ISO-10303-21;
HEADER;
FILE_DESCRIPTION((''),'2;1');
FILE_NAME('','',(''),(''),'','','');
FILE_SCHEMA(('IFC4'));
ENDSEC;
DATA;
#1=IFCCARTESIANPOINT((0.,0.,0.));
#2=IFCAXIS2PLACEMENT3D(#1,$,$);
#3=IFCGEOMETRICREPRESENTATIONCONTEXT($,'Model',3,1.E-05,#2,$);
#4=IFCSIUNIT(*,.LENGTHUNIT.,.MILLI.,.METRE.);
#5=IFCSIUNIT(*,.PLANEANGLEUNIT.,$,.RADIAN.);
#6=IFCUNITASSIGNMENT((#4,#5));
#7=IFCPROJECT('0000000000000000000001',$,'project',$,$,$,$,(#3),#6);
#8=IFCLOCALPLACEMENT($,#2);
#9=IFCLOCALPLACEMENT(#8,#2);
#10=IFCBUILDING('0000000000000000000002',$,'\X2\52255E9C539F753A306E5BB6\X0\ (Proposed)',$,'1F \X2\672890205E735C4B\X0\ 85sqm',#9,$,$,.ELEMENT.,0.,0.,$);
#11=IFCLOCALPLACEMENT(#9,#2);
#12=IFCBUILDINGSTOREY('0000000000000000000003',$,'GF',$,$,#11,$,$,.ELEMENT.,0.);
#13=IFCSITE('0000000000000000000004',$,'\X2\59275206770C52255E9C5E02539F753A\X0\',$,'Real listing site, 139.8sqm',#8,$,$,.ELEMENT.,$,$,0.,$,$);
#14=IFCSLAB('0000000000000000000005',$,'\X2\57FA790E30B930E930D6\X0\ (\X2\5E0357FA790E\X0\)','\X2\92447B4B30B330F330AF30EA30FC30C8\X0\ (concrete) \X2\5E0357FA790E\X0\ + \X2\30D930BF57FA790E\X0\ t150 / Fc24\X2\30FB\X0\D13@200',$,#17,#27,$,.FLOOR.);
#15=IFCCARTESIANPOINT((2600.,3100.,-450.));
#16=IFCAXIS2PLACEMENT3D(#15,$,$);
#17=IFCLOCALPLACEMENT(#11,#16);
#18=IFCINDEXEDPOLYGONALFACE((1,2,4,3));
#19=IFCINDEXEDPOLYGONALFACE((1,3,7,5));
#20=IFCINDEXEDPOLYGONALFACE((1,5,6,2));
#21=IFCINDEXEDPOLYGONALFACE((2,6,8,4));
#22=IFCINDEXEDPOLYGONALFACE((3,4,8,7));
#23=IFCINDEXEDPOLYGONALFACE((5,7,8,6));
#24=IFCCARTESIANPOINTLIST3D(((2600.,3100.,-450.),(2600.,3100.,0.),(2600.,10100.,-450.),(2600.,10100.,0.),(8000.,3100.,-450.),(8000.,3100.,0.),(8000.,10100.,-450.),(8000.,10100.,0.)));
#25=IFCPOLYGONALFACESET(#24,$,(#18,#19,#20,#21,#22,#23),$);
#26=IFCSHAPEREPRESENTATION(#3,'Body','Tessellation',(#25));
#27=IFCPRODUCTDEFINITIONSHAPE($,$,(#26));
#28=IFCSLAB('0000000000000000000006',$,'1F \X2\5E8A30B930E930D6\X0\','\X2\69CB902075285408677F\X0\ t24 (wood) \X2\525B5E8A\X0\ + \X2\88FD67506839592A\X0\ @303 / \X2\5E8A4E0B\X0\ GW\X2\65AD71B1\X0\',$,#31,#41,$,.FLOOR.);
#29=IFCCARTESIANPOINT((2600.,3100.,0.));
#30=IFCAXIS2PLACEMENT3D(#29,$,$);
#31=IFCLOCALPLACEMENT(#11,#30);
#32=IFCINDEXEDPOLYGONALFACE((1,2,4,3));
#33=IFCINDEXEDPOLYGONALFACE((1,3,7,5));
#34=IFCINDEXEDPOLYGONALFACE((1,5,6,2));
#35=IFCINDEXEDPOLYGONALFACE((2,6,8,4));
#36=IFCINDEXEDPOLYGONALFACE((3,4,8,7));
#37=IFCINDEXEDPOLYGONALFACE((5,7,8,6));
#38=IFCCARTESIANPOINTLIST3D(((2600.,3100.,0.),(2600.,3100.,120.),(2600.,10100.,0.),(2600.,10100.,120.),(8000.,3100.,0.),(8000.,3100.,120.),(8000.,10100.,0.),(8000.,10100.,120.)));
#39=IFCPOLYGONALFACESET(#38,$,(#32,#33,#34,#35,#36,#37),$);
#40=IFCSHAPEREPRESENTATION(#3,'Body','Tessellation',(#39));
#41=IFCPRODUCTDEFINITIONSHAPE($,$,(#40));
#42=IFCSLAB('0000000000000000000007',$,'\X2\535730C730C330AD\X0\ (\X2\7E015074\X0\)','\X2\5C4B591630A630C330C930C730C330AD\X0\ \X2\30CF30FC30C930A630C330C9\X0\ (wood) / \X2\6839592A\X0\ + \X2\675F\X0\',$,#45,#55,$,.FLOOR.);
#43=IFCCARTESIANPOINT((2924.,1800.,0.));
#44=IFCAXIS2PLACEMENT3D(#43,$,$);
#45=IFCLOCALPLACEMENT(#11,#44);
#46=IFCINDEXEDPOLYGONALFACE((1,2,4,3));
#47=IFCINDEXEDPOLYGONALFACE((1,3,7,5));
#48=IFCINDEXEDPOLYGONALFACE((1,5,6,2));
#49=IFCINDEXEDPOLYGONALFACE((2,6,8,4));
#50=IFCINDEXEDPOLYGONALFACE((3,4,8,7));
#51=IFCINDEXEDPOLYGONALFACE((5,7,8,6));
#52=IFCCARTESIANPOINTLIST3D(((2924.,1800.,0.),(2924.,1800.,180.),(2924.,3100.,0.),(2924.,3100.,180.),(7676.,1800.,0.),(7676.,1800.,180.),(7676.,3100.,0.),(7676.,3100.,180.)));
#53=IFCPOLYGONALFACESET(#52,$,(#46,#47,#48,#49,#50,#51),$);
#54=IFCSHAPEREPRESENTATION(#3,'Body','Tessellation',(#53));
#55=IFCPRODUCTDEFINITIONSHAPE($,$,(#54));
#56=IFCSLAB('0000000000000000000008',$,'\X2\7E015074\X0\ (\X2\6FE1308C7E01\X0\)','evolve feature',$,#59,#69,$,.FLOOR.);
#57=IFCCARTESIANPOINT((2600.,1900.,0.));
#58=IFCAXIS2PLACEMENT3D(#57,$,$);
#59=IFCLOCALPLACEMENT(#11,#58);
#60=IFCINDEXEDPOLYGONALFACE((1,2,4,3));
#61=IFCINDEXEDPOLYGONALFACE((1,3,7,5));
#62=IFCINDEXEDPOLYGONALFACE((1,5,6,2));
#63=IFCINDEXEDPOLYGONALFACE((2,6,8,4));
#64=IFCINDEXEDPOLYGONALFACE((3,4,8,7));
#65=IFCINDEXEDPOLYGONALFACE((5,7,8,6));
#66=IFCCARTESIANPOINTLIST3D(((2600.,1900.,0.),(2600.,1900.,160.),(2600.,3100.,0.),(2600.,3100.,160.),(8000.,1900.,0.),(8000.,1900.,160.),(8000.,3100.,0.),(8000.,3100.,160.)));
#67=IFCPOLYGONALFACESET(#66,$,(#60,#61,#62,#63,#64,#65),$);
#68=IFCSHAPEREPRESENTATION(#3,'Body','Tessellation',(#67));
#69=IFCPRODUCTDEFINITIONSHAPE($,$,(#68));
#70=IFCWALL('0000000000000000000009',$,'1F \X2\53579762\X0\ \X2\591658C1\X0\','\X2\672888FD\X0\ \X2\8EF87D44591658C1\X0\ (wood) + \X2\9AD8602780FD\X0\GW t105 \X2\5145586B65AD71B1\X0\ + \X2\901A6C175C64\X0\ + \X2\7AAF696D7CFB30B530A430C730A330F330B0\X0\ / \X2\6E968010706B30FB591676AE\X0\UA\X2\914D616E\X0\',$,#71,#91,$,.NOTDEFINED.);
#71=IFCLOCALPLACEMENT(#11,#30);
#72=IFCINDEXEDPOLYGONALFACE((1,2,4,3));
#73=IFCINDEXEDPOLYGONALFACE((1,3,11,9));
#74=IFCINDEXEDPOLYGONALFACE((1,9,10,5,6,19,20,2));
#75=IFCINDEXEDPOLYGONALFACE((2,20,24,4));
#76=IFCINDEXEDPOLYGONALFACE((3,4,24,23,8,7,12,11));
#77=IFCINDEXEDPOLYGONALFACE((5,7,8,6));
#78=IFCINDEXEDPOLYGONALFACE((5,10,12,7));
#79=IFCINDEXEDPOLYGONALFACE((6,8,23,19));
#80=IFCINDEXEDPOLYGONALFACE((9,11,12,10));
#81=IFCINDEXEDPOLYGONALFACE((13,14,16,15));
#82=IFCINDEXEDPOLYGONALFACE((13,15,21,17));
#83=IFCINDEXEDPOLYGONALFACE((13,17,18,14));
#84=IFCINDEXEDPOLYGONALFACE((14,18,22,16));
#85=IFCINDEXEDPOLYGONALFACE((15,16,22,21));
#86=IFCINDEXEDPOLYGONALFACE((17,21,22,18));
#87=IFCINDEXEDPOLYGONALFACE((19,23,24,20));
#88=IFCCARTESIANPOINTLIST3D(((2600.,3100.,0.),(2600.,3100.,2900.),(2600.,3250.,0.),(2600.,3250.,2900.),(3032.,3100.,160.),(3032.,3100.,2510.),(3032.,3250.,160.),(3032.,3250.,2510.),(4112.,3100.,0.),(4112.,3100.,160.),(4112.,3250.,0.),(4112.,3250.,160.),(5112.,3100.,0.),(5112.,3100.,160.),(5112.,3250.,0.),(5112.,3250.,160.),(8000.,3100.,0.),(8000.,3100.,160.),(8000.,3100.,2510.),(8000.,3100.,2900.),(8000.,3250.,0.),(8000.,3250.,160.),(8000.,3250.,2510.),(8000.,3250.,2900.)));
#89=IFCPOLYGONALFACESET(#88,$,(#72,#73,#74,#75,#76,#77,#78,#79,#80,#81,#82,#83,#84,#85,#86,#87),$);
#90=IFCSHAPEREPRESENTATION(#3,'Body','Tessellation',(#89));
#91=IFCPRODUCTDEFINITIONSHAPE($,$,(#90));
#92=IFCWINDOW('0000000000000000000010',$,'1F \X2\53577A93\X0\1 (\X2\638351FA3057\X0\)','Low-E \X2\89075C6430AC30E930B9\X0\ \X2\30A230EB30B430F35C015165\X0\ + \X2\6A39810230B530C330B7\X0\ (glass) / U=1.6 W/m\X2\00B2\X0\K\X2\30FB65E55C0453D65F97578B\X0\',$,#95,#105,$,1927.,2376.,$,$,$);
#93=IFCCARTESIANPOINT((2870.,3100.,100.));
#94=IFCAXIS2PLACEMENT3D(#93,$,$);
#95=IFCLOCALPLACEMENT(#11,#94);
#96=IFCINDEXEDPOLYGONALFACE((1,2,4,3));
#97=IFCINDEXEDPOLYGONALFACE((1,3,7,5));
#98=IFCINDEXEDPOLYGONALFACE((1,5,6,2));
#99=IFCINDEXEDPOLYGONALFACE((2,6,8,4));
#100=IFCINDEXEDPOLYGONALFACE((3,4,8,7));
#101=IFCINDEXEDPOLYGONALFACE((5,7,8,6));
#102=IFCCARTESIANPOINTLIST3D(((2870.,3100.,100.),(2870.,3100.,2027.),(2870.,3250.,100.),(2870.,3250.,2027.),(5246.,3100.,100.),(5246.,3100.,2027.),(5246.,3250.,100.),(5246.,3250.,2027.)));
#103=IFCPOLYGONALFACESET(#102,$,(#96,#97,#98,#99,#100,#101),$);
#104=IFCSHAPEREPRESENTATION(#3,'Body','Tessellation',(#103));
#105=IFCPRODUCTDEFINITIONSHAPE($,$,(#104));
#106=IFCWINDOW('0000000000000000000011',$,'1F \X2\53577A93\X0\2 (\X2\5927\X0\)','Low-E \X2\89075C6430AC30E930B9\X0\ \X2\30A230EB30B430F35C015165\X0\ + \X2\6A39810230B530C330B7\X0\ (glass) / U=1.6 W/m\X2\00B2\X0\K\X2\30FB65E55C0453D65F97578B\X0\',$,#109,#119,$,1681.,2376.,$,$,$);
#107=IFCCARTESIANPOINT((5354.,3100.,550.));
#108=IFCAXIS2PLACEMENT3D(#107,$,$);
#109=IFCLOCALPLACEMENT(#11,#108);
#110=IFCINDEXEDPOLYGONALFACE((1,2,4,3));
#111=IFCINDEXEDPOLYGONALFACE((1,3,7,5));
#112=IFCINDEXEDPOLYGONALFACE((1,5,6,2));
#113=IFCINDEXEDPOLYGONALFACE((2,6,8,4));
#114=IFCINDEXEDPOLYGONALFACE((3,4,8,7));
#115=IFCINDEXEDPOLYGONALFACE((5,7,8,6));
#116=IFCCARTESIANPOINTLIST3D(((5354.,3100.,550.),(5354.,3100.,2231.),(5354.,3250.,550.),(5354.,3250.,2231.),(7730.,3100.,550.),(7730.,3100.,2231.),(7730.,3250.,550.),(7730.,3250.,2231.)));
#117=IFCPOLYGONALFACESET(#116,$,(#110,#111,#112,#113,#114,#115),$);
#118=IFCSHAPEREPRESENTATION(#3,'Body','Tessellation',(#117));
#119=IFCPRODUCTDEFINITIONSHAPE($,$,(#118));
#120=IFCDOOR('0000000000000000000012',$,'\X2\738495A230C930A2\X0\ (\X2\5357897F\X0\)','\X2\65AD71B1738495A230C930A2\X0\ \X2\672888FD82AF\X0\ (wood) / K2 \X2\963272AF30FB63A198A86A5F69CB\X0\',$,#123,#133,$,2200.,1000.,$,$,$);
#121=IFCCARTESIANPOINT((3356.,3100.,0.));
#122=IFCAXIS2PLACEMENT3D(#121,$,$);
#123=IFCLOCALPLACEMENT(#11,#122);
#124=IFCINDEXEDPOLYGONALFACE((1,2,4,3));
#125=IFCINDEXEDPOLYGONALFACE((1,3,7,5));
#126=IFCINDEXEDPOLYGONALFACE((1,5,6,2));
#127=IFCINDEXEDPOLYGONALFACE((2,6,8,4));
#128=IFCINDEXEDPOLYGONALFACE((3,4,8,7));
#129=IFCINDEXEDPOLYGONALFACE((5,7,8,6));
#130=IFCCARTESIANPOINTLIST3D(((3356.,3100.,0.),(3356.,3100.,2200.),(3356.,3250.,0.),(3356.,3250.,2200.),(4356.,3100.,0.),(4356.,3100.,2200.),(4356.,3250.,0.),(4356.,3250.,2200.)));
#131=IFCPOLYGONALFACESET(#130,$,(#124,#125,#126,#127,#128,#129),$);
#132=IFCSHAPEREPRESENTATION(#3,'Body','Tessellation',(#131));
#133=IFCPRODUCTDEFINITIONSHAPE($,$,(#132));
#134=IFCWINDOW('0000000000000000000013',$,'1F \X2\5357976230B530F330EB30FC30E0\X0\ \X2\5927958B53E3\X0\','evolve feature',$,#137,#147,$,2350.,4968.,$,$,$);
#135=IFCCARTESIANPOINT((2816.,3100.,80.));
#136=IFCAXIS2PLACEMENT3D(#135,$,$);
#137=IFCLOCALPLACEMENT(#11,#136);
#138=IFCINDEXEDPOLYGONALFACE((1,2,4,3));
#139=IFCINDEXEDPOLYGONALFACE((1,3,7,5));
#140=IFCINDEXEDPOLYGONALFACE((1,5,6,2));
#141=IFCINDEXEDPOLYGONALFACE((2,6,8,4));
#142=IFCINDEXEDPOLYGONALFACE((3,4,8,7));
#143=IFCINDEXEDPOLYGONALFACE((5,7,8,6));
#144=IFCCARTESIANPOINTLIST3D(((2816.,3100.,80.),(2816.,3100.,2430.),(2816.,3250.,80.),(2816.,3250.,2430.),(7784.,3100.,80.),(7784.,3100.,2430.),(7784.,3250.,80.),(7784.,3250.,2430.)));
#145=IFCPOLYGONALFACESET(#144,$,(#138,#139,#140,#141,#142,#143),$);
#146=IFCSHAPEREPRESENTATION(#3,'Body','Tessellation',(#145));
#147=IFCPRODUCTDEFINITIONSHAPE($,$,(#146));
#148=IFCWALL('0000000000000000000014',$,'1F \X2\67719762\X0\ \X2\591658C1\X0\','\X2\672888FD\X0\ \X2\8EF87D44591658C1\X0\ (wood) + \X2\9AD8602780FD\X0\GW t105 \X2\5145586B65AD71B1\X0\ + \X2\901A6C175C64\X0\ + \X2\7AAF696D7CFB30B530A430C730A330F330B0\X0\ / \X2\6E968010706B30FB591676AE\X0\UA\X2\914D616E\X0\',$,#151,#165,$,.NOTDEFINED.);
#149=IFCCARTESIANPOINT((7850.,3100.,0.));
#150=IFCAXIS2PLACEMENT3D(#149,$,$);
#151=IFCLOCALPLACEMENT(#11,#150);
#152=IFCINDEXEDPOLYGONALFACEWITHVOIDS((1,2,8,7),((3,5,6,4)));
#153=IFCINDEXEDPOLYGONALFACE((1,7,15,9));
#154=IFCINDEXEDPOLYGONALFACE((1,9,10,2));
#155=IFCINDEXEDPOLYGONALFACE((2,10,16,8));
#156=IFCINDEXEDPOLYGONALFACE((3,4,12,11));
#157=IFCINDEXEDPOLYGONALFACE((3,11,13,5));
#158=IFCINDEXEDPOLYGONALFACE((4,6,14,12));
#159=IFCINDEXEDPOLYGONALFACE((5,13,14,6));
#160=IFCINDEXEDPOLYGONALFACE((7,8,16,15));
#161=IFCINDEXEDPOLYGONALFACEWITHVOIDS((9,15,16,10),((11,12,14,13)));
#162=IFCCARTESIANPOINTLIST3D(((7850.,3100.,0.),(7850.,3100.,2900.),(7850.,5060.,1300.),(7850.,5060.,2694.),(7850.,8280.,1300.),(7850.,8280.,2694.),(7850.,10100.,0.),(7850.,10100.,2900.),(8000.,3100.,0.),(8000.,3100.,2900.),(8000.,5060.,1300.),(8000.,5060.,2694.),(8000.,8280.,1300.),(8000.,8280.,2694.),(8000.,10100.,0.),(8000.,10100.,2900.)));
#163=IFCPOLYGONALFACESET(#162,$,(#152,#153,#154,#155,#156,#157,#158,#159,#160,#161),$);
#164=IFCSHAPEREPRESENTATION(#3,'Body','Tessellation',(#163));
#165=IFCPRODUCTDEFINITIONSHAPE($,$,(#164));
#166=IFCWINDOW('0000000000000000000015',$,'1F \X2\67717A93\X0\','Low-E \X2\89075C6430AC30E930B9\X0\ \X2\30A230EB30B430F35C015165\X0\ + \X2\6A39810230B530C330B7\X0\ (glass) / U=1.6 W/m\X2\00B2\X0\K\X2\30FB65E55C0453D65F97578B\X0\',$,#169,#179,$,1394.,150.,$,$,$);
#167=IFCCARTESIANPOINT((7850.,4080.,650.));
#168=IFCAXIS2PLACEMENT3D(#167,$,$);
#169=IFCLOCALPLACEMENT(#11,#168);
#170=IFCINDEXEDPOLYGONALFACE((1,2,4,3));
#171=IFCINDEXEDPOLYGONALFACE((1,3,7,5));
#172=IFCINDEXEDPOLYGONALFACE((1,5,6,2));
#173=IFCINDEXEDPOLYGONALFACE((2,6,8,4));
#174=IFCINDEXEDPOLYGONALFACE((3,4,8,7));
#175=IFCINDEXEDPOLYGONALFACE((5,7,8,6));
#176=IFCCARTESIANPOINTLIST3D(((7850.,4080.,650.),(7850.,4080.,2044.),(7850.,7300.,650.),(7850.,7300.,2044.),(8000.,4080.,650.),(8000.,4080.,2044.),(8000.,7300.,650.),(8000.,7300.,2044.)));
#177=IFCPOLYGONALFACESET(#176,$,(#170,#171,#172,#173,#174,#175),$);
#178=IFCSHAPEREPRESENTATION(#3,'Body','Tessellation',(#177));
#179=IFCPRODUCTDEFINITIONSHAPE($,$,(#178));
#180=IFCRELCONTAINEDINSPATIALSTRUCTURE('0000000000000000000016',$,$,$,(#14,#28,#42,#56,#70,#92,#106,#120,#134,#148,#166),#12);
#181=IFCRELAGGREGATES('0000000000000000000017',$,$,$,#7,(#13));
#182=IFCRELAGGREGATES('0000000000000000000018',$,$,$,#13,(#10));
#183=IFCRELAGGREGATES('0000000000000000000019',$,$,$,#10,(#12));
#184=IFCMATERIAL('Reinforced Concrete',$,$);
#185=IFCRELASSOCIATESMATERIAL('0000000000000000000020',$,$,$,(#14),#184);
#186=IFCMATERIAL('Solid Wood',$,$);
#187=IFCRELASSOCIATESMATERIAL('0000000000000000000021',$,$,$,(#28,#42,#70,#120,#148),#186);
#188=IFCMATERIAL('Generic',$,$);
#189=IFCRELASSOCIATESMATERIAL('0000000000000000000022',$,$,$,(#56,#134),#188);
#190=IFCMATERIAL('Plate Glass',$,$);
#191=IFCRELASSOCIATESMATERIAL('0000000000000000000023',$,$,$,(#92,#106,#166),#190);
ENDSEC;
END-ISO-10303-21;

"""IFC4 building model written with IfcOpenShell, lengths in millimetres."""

from ifc_helpers import new_model, si_unit, frame, frame_2d, origin, place, context, project, spatial, rectangle, extrude, material, element, fill, save


model = new_model("IFC4")

# Units and contexts
model_context = context("Model", 3, precision=1e-05, world=origin())
ifc_project = project(units=[si_unit("LENGTHUNIT", "METRE", prefix="MILLI"), si_unit("PLANEANGLEUNIT", "RADIAN")], contexts=[model_context])

# Site, building, storey
site_placement = place(None, origin())
site = spatial("IfcSite", under=ifc_project, at=site_placement, Name="大分県別府市原町", ObjectType="Real listing site, 139.8sqm", CompositionType="ELEMENT", RefElevation=0.0)
building_placement = place(site_placement, origin())
building = spatial("IfcBuilding", under=site, at=building_placement, Name="別府原町の家 (Proposed)", ObjectType="1F 木造平屋 85sqm", CompositionType="ELEMENT", ElevationOfRefHeight=0.0, ElevationOfTerrain=0.0)
storey_placement = place(building_placement, origin())
storey = spatial("IfcBuildingStorey", under=building, at=storey_placement, Name="GF", CompositionType="ELEMENT", Elevation=0.0)

# Slabs
ifc_material_1 = material(Name="Reinforced Concrete")
slab_1_placement = place(storey_placement, frame((2600.0, 3100.0, -450.0)))
element("IfcSlab", 1, at=slab_1_placement, inside=storey, material=ifc_material_1, Name="基礎スラブ (布基礎)", Description="鉄筋コンクリート (concrete) 布基礎 + ベタ基礎 t150 / Fc24・D13@200", PredefinedType="FLOOR", context=model_context, shape_type="SweptSolid", body=[
    extrude(rectangle(XDim=5400.0, YDim=7000.0, at=frame_2d((2700.0, 3500.0))), frame((2600.0, 3100.0, -450.0)), (0.0, 0.0, 1.0), 450.0),
])
ifc_material_2 = material(Name="Solid Wood")
slab_2_placement = place(storey_placement, frame((2600.0, 3100.0, 0.0)))
element("IfcSlab", 2, at=slab_2_placement, inside=storey, material=ifc_material_2, Name="1F 床スラブ", Description="構造用合板 t24 (wood) 剛床 + 製材根太 @303 / 床下 GW断熱", PredefinedType="FLOOR", context=model_context, shape_type="SweptSolid", body=[
    extrude(rectangle(XDim=5400.0, YDim=7000.0, at=frame_2d((2700.0, 3500.0))), frame((2600.0, 3100.0, 0.0)), (0.0, 0.0, 1.0), 120.0),
])
slab_3_placement = place(storey_placement, frame((2924.0, 1800.0, 0.0)))
element("IfcSlab", 3, at=slab_3_placement, inside=storey, material=ifc_material_2, Name="南デッキ (縁側)", Description="屋外ウッドデッキ ハードウッド (wood) / 根太 + 束", PredefinedType="FLOOR", context=model_context, shape_type="SweptSolid", body=[
    extrude(rectangle(XDim=4752.0, YDim=1300.0, at=frame_2d((2376.0, 650.0))), frame((2924.0, 1800.0, 0.0)), (0.0, 0.0, 1.0), 180.0),
])
ifc_material_3 = material(Name="Generic")
slab_4_placement = place(storey_placement, frame((2600.0, 1900.0, 0.0)))
element("IfcSlab", 4, at=slab_4_placement, inside=storey, material=ifc_material_3, Name="縁側 (濡れ縁)", Description="evolve feature", PredefinedType="FLOOR", context=model_context, shape_type="SweptSolid", body=[
    extrude(rectangle(XDim=5400.0, YDim=1200.0, at=frame_2d((2700.0, 600.0))), frame((2600.0, 1900.0, 0.0)), (0.0, 0.0, 1.0), 160.0),
])

# Wall, openings, windows, door
wall_1_placement = place(storey_placement, frame((2600.0, 3100.0, 0.0)))
wall_1 = element("IfcWall", 5, at=wall_1_placement, inside=storey, material=ifc_material_2, Name="1F 南面 外壁", Description="木製 軸組外壁 (wood) + 高性能GW t105 充填断熱 + 通気層 + 窯業系サイディング / 準耐火・外皮UA配慮", PredefinedType="NOTDEFINED", context=model_context, shape_type="SweptSolid", body=[
    extrude(rectangle(XDim=5400.0, YDim=150.0, at=frame_2d((2700.0, 75.0))), frame((2600.0, 3100.0, 0.0)), (0.0, 0.0, 1.0), 2900.0),
])
opening_1_placement = place(storey_placement, frame((2870.0, 3100.0, 100.0)))
opening_1 = element("IfcOpeningElement", 6, at=opening_1_placement, cuts=wall_1, PredefinedType="NOTDEFINED", context=model_context, shape_type="SweptSolid", body=[
    extrude(rectangle(XDim=2376.0, YDim=150.0, at=frame_2d((1188.0, 75.0))), frame((2870.0, 3100.0, 100.0)), (0.0, 0.0, 1.0), 1927.0),
])
opening_2_placement = place(storey_placement, frame((5354.0, 3100.0, 550.0)))
opening_2 = element("IfcOpeningElement", 7, at=opening_2_placement, cuts=wall_1, PredefinedType="NOTDEFINED", context=model_context, shape_type="SweptSolid", body=[
    extrude(rectangle(XDim=2376.0, YDim=150.0, at=frame_2d((1188.0, 75.0))), frame((5354.0, 3100.0, 550.0)), (0.0, 0.0, 1.0), 1681.0),
])
opening_3_placement = place(storey_placement, frame((3356.0, 3100.0, 0.0)))
opening_3 = element("IfcOpeningElement", 8, at=opening_3_placement, cuts=wall_1, PredefinedType="NOTDEFINED", context=model_context, shape_type="SweptSolid", body=[
    extrude(rectangle(XDim=1000.0, YDim=150.0, at=frame_2d((500.0, 75.0))), frame((3356.0, 3100.0, 0.0)), (0.0, 0.0, 1.0), 2200.0),
])
opening_4_placement = place(storey_placement, frame((2816.0, 3100.0, 80.0)))
opening_4 = element("IfcOpeningElement", 9, at=opening_4_placement, cuts=wall_1, PredefinedType="NOTDEFINED", context=model_context, shape_type="SweptSolid", body=[
    extrude(rectangle(XDim=4968.0, YDim=150.0, at=frame_2d((2484.0, 75.0))), frame((2816.0, 3100.0, 80.0)), (0.0, 0.0, 1.0), 2350.0),
])
ifc_material_4 = material(Name="Plate Glass")
window_1_placement = place(storey_placement, frame((2870.0, 3100.0, 100.0)))
window_1 = element("IfcWindow", 10, at=window_1_placement, inside=storey, material=ifc_material_4, Name="1F 南窓1 (掃出し)", Description="Low-E 複層ガラス アルゴン封入 + 樹脂サッシ (glass) / U=1.6 W/m²K・日射取得型", OverallHeight=1927.0, OverallWidth=2376.0, context=model_context, shape_type="SweptSolid", body=[
    extrude(rectangle(XDim=2376.0, YDim=150.0, at=frame_2d((1188.0, 75.0))), frame((2870.0, 3100.0, 100.0)), (0.0, 0.0, 1.0), 1927.0),
])
fill(opening_1, window_1)
window_2_placement = place(storey_placement, frame((5354.0, 3100.0, 550.0)))
window_2 = element("IfcWindow", 11, at=window_2_placement, inside=storey, material=ifc_material_4, Name="1F 南窓2 (大)", Description="Low-E 複層ガラス アルゴン封入 + 樹脂サッシ (glass) / U=1.6 W/m²K・日射取得型", OverallHeight=1681.0, OverallWidth=2376.0, context=model_context, shape_type="SweptSolid", body=[
    extrude(rectangle(XDim=2376.0, YDim=150.0, at=frame_2d((1188.0, 75.0))), frame((5354.0, 3100.0, 550.0)), (0.0, 0.0, 1.0), 1681.0),
])
fill(opening_2, window_2)
door_placement = place(storey_placement, frame((3356.0, 3100.0, 0.0)))
door = element("IfcDoor", 12, at=door_placement, inside=storey, material=ifc_material_2, Name="玄関ドア (南西)", Description="断熱玄関ドア 木製芯 (wood) / K2 防犯・採風機構", OverallHeight=2200.0, OverallWidth=1000.0, context=model_context, shape_type="SweptSolid", body=[
    extrude(rectangle(XDim=1000.0, YDim=150.0, at=frame_2d((500.0, 75.0))), frame((3356.0, 3100.0, 0.0)), (0.0, 0.0, 1.0), 2200.0),
])
fill(opening_3, door)
window_3_placement = place(storey_placement, frame((2816.0, 3100.0, 80.0)))
window_3 = element("IfcWindow", 13, at=window_3_placement, inside=storey, material=ifc_material_3, Name="1F 南面サンルーム 大開口", Description="evolve feature", OverallHeight=2350.0, OverallWidth=4968.0, context=model_context, shape_type="SweptSolid", body=[
    extrude(rectangle(XDim=4968.0, YDim=150.0, at=frame_2d((2484.0, 75.0))), frame((2816.0, 3100.0, 80.0)), (0.0, 0.0, 1.0), 2350.0),
])
fill(opening_4, window_3)

# Wall, opening, window
wall_2_placement = place(storey_placement, frame((7850.0, 3100.0, 0.0)))
wall_2 = element("IfcWall", 14, at=wall_2_placement, inside=storey, material=ifc_material_2, Name="1F 東面 外壁", Description="木製 軸組外壁 (wood) + 高性能GW t105 充填断熱 + 通気層 + 窯業系サイディング / 準耐火・外皮UA配慮", PredefinedType="NOTDEFINED", context=model_context, shape_type="SweptSolid", body=[
    extrude(rectangle(XDim=150.0, YDim=7000.0, at=frame_2d((75.0, 3500.0))), frame((7850.0, 3100.0, 0.0)), (0.0, 0.0, 1.0), 2900.0),
])
opening_5_placement = place(storey_placement, frame((7850.0, 4080.0, 650.0)))
opening_5 = element("IfcOpeningElement", 15, at=opening_5_placement, cuts=wall_2, PredefinedType="NOTDEFINED", context=model_context, shape_type="SweptSolid", body=[
    extrude(rectangle(XDim=150.0, YDim=3220.0, at=frame_2d((75.0, 1610.0))), frame((7850.0, 4080.0, 650.0)), (0.0, 0.0, 1.0), 1394.0),
])
window_4_placement = place(storey_placement, frame((7850.0, 4080.0, 650.0)))
window_4 = element("IfcWindow", 16, at=window_4_placement, inside=storey, material=ifc_material_4, Name="1F 東窓", Description="Low-E 複層ガラス アルゴン封入 + 樹脂サッシ (glass) / U=1.6 W/m²K・日射取得型", OverallHeight=1394.0, OverallWidth=150.0, context=model_context, shape_type="SweptSolid", body=[
    extrude(rectangle(XDim=150.0, YDim=3220.0, at=frame_2d((75.0, 1610.0))), frame((7850.0, 4080.0, 650.0)), (0.0, 0.0, 1.0), 1394.0),
])
fill(opening_5, window_4)

save(model, "model.ifc")
